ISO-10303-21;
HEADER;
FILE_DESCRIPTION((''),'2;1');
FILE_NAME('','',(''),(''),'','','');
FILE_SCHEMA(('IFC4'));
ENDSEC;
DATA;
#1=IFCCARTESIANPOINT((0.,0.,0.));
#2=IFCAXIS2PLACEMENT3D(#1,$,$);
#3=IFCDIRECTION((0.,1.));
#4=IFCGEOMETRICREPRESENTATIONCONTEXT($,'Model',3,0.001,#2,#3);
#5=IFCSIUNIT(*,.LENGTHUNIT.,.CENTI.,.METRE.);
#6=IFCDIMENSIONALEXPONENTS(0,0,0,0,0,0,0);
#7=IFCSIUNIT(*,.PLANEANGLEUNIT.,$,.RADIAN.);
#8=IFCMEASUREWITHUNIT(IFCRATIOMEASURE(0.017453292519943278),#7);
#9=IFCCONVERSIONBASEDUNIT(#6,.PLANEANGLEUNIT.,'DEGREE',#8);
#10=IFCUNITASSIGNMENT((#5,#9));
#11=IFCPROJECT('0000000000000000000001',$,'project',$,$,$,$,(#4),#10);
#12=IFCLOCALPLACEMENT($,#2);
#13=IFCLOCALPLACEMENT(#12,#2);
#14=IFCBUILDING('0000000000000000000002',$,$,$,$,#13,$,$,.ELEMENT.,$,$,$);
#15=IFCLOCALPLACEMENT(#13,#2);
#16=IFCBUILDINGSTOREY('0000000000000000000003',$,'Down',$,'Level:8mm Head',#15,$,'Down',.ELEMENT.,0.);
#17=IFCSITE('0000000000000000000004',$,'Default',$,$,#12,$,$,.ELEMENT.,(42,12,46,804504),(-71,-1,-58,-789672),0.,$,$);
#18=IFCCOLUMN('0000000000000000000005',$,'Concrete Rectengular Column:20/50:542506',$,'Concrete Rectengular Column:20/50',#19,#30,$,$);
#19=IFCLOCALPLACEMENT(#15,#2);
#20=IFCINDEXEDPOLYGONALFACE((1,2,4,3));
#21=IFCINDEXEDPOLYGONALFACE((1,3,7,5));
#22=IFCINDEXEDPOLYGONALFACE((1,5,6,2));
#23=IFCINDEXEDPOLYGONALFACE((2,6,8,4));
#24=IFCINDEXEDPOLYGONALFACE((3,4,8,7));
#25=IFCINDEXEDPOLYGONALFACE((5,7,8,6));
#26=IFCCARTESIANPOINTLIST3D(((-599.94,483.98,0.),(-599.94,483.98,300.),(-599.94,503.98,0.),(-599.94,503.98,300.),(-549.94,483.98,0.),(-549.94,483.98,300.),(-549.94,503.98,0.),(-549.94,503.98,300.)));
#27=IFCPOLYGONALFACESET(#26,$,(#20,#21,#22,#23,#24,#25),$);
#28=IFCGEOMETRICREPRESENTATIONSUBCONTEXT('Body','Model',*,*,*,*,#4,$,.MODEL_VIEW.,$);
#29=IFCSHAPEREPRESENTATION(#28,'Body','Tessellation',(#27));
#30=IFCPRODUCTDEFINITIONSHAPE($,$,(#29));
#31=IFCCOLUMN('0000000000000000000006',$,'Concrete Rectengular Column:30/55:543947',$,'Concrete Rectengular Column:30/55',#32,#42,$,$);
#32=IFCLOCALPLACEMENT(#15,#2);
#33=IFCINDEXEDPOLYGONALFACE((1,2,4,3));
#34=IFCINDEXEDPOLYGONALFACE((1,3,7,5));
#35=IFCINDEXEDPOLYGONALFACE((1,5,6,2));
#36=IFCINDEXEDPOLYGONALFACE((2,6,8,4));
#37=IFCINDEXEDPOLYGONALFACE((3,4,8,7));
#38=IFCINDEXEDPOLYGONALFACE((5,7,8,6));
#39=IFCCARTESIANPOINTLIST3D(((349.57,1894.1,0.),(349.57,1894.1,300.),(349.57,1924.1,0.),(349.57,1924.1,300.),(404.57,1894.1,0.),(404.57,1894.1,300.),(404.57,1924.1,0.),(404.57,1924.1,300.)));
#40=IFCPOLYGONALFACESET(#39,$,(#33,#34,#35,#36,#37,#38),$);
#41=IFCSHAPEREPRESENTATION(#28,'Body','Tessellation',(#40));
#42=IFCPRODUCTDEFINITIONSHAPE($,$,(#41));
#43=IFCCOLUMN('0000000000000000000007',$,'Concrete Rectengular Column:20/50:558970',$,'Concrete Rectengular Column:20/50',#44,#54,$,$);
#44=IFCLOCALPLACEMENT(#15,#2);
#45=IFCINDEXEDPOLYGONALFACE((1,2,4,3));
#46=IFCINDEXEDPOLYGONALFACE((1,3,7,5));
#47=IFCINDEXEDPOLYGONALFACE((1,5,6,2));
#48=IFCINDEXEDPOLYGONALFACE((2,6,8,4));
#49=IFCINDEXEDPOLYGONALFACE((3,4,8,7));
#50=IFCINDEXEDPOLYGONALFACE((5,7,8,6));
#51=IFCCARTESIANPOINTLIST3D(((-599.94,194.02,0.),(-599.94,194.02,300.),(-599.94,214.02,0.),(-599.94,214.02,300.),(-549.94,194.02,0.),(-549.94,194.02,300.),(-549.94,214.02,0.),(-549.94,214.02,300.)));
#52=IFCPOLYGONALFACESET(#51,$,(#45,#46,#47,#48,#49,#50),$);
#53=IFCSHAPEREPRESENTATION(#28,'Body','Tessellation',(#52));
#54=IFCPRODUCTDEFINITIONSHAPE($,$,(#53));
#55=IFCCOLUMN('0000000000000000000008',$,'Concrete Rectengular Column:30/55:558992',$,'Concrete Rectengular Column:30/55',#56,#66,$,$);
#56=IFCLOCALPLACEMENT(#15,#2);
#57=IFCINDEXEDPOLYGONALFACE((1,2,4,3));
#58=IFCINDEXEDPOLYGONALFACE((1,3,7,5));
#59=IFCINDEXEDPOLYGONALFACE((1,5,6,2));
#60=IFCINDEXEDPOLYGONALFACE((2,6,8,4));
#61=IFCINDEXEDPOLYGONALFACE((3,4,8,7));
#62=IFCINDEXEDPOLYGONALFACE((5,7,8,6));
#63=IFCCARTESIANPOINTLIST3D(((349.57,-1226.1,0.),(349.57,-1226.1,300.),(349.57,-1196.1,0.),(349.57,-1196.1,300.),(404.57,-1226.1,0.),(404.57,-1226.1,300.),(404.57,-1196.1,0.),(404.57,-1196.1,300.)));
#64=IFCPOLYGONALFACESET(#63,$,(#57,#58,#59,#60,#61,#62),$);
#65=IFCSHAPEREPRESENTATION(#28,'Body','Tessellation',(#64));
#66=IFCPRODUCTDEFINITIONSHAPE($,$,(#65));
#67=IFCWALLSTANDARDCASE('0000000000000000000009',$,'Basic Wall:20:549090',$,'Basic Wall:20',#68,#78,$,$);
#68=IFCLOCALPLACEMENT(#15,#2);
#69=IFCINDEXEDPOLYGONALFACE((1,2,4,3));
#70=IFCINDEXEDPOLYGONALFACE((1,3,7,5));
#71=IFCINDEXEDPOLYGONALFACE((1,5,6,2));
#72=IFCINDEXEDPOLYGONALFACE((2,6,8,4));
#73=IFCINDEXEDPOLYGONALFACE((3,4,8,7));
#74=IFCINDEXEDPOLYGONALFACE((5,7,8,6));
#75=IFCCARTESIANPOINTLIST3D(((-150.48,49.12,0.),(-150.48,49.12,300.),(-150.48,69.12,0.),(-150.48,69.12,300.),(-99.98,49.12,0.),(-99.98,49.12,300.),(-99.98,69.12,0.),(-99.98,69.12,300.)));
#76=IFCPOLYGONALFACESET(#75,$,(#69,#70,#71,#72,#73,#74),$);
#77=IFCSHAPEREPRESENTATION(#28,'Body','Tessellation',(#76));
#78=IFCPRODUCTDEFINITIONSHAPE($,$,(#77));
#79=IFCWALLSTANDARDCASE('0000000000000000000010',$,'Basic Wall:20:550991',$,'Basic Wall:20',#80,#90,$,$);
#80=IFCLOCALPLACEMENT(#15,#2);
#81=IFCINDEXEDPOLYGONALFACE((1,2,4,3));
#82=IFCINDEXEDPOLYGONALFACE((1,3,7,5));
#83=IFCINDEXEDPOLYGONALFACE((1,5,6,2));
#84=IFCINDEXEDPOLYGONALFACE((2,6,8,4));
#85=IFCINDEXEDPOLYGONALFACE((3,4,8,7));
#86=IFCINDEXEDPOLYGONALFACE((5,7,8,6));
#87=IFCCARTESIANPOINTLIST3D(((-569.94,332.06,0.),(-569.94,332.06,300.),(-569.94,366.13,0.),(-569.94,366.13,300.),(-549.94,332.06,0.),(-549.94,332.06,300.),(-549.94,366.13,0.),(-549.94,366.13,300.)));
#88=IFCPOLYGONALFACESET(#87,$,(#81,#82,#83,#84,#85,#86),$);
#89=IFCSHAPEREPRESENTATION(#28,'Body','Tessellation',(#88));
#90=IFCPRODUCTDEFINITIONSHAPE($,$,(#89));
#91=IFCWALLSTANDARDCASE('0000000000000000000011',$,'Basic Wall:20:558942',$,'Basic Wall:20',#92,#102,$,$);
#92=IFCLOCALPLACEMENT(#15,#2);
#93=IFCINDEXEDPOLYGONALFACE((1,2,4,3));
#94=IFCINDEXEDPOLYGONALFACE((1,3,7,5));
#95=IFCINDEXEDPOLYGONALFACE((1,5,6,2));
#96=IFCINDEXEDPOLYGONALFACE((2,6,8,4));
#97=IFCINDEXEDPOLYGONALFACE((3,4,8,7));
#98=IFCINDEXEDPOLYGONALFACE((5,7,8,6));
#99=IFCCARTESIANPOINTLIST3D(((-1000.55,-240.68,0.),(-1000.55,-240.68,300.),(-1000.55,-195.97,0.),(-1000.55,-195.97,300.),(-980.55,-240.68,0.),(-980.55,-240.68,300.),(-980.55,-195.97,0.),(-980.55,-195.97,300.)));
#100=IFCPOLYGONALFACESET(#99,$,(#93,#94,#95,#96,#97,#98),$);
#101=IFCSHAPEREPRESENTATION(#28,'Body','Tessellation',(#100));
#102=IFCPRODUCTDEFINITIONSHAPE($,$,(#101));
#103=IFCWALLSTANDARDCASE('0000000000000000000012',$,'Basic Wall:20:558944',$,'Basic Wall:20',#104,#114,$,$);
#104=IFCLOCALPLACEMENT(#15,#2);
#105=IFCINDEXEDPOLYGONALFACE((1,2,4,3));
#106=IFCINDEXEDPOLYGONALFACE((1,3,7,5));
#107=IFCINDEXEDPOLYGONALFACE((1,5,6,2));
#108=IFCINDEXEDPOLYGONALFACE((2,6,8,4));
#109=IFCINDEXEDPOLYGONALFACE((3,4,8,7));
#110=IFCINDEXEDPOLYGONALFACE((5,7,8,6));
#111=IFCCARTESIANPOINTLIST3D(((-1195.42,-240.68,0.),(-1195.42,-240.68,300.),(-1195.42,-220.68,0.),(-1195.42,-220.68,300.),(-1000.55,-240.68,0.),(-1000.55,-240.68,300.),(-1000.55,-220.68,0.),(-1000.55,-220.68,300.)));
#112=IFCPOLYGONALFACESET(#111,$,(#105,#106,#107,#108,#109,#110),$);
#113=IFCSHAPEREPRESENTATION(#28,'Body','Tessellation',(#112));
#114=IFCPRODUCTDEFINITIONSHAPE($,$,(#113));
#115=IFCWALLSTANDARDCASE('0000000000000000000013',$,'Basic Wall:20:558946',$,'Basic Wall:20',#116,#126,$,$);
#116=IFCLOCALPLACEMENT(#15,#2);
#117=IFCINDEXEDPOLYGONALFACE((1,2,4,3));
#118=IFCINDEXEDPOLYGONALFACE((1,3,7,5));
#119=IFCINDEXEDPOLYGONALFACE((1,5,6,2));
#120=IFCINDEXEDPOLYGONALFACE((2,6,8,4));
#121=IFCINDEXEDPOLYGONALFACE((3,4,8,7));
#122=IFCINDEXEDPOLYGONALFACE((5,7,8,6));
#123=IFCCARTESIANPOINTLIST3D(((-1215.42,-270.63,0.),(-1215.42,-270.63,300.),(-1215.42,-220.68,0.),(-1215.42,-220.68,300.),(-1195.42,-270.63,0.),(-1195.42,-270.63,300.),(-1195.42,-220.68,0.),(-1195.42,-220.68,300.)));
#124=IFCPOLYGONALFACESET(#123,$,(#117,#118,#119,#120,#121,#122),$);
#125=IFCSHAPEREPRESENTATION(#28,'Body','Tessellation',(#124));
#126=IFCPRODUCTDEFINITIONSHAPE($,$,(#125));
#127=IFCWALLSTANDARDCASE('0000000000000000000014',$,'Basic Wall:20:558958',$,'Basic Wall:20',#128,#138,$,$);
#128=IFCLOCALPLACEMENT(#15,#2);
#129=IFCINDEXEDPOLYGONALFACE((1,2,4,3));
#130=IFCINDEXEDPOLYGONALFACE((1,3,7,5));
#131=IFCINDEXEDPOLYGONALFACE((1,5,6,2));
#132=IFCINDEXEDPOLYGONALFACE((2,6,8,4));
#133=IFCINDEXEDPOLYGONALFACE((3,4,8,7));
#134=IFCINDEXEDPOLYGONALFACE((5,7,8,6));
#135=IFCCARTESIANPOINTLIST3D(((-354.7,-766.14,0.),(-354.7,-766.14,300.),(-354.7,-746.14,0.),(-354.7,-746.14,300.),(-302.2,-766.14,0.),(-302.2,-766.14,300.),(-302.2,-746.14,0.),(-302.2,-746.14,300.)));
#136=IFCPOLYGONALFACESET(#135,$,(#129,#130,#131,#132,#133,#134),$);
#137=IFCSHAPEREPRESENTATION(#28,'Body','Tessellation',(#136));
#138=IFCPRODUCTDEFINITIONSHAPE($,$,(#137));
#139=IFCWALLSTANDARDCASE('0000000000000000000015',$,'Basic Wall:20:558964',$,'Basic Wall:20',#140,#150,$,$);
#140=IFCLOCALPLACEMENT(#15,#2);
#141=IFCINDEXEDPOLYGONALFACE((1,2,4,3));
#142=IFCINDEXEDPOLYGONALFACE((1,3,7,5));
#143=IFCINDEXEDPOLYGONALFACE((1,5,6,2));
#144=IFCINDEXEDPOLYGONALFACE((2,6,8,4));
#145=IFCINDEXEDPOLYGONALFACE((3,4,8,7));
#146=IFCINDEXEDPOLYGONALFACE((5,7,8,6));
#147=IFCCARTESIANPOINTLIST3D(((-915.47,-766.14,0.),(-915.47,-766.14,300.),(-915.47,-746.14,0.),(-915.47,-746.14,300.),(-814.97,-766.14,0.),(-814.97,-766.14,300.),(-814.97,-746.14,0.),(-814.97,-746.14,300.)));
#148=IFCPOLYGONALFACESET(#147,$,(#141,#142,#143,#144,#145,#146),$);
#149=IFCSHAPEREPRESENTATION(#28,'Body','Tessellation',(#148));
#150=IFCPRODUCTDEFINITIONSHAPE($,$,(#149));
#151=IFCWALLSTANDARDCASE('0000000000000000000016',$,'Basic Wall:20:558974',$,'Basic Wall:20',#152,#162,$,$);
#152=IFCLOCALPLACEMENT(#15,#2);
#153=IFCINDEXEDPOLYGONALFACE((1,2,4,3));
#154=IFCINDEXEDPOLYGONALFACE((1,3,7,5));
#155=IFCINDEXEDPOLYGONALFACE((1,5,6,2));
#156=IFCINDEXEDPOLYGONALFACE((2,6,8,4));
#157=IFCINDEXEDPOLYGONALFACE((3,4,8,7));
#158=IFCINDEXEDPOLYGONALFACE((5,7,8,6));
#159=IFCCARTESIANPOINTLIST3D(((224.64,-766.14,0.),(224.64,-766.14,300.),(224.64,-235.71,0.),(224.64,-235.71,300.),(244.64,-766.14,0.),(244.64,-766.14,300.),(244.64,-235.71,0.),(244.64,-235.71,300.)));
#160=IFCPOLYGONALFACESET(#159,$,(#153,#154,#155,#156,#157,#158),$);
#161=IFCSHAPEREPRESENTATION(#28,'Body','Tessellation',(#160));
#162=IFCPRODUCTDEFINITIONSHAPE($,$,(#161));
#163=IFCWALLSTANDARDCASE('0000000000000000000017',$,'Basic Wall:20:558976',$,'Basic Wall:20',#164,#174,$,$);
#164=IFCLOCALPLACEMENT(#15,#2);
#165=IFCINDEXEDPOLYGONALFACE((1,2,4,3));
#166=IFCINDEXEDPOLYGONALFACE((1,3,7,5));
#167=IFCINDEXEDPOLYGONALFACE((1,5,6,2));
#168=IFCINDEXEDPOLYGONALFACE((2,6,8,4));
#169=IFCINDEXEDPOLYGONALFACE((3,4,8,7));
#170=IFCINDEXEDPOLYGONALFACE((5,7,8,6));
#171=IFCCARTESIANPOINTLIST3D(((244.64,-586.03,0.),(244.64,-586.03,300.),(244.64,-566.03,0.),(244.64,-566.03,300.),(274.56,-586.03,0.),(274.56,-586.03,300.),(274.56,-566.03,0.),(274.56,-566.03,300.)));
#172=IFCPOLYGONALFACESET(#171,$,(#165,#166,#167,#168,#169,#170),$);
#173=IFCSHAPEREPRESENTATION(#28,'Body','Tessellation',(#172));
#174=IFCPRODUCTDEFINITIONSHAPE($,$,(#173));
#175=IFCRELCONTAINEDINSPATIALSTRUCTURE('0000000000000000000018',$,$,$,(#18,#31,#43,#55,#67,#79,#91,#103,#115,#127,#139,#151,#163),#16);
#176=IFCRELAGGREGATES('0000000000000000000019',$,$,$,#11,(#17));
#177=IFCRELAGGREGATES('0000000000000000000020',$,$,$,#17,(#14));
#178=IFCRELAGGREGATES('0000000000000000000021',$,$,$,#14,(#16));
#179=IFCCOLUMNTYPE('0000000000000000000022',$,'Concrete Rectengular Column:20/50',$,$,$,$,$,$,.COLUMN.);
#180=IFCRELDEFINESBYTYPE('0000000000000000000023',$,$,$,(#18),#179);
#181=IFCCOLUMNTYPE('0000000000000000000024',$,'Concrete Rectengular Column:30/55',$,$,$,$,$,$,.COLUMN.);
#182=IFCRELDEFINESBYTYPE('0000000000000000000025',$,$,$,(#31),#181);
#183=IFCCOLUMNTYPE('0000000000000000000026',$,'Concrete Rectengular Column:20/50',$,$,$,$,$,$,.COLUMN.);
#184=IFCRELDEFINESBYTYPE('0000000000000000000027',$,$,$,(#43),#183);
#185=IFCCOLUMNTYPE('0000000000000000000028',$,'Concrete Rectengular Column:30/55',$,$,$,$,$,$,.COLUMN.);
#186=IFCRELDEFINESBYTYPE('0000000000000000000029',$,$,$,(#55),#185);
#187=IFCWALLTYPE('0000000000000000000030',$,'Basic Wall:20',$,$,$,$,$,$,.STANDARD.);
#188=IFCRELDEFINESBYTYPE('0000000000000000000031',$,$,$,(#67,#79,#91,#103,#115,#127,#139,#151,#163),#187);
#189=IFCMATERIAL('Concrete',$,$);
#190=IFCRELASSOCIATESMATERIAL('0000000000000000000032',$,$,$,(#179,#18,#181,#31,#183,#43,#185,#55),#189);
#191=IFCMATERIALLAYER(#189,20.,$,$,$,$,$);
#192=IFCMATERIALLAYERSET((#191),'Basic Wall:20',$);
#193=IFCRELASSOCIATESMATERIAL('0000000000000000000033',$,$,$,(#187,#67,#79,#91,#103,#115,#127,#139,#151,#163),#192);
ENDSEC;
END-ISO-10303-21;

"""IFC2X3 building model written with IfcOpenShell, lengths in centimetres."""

from ifc_helpers import new_model, entity, si_unit, converted_unit, direction, frame, frame_2d, origin, origin_2d_with_axis, place, context, subcontext, project, spatial, rectangle, extrude, source, transform, mapped, material, layer, layer_set, layer_usage, type_object, type_shapes, element, save


model = new_model("IFC2X3")

# Units and contexts
model_context = context("Model", 3, precision=0.001, world=origin(), true_north=direction((0.0, 1.0)))
body_context = subcontext(model_context, "Body", "Model", "MODEL_VIEW")
ifc_project = project(units=[si_unit("LENGTHUNIT", "METRE", prefix="CENTI"), converted_unit("PLANEANGLEUNIT", "DEGREE", entity("IfcRatioMeasure", 0.017453292519943278), si_unit("PLANEANGLEUNIT", "RADIAN"), dimensions=[0, 0, 0, 0, 0, 0, 0])], contexts=[model_context])

# Site, building, storey
site_placement = place(None, origin())
site = spatial("IfcSite", under=ifc_project, at=site_placement, Name="Default", CompositionType="ELEMENT", RefLatitude=(42, 12, 46, 804504), RefLongitude=(-71, -1, -58, -789672), RefElevation=0.0)
building_placement = place(site_placement, origin())
building = spatial("IfcBuilding", under=site, at=building_placement, CompositionType="ELEMENT")
storey_placement = place(building_placement, origin())
storey = spatial("IfcBuildingStorey", under=building, at=storey_placement, Name="Down", ObjectType="Level:8mm Head", LongName="Down", CompositionType="ELEMENT", Elevation=0.0)

# Columns
ifc_material = material(Name="Concrete")
column_type_1 = type_object("IfcColumnType", Name="Concrete Rectengular Column:20/50", PredefinedType="COLUMN", material=ifc_material)
shared_shape_1 = source(origin(), body_context, "Body", "SweptSolid", [
    extrude(rectangle(XDim=20.0, YDim=50.0, at=frame_2d((0.0, 0.0), x_axis=(1.0, 0.0))), frame((-574.94, 493.98, 0.0), z_axis=(0.0, 0.0, 1.0), x_axis=(0.0, -1.0, 0.0)), (0.0, 0.0, 1.0), 300.0),
])
type_shapes(column_type_1, [shared_shape_1])
column_1_placement = place(storey_placement, origin())
element("IfcColumn", 1, at=column_1_placement, inside=storey, type_object=column_type_1, material=ifc_material, Name="Concrete Rectengular Column:20/50:542506", ObjectType="Concrete Rectengular Column:20/50", context=body_context, shape_type="MappedRepresentation", body=[
    mapped(shared_shape_1, transform((0.0, 0.0, 0.0), scale=1.0)),
])
column_type_2 = type_object("IfcColumnType", Name="Concrete Rectengular Column:30/55", PredefinedType="COLUMN", material=ifc_material)
shared_shape_2 = source(origin(), body_context, "Body", "SweptSolid", [
    extrude(rectangle(XDim=30.0, YDim=55.0, at=origin_2d_with_axis()), frame((377.07, 1909.1, 0.0), z_axis=(0.0, 0.0, 1.0), x_axis=(0.0, -1.0, 0.0)), (0.0, 0.0, 1.0), 300.0),
])
type_shapes(column_type_2, [shared_shape_2])
column_2_placement = place(storey_placement, origin())
element("IfcColumn", 2, at=column_2_placement, inside=storey, type_object=column_type_2, material=ifc_material, Name="Concrete Rectengular Column:30/55:543947", ObjectType="Concrete Rectengular Column:30/55", context=body_context, shape_type="MappedRepresentation", body=[
    mapped(shared_shape_2, transform((0.0, 0.0, 0.0), scale=1.0)),
])
column_type_3 = type_object("IfcColumnType", Name="Concrete Rectengular Column:20/50", PredefinedType="COLUMN", material=ifc_material)
shared_shape_3 = source(origin(), body_context, "Body", "SweptSolid", [
    extrude(rectangle(XDim=20.0, YDim=50.0, at=frame_2d((0.0, 0.0), x_axis=(1.0, 0.0))), frame((-574.94, 204.02, 0.0), z_axis=(0.0, 0.0, 1.0), x_axis=(0.0, -1.0, 0.0)), (0.0, 0.0, 1.0), 300.0),
])
type_shapes(column_type_3, [shared_shape_3])
column_3_placement = place(storey_placement, origin())
element("IfcColumn", 3, at=column_3_placement, inside=storey, type_object=column_type_3, material=ifc_material, Name="Concrete Rectengular Column:20/50:558970", ObjectType="Concrete Rectengular Column:20/50", context=body_context, shape_type="MappedRepresentation", body=[
    mapped(shared_shape_3, transform((0.0, 0.0, 0.0), scale=1.0)),
])
column_type_4 = type_object("IfcColumnType", Name="Concrete Rectengular Column:30/55", PredefinedType="COLUMN", material=ifc_material)
shared_shape_4 = source(origin(), body_context, "Body", "SweptSolid", [
    extrude(rectangle(XDim=30.0, YDim=55.0, at=origin_2d_with_axis()), frame((377.07, -1211.1, 0.0), z_axis=(0.0, 0.0, 1.0), x_axis=(0.0, -1.0, 0.0)), (0.0, 0.0, 1.0), 300.0),
])
type_shapes(column_type_4, [shared_shape_4])
column_4_placement = place(storey_placement, origin())
element("IfcColumn", 4, at=column_4_placement, inside=storey, type_object=column_type_4, material=ifc_material, Name="Concrete Rectengular Column:30/55:558992", ObjectType="Concrete Rectengular Column:30/55", context=body_context, shape_type="MappedRepresentation", body=[
    mapped(shared_shape_4, transform((0.0, 0.0, 0.0), scale=1.0)),
])

# Walls
ifc_layer_1 = layer(ifc_material, 20.0)
ifc_layer_set_1 = layer_set([ifc_layer_1], Name="Basic Wall:20")
ifc_layer_usage_1 = layer_usage(ifc_layer_set_1, "AXIS2", "POSITIVE", -10.0)
wall_type_1 = type_object("IfcWallType", Name="Basic Wall:20", PredefinedType="STANDARD", material=ifc_layer_set_1)
wall_1_placement = place(storey_placement, frame((-150.48, 59.12, 0.0)))
element("IfcWallStandardCase", 5, at=wall_1_placement, inside=storey, type_object=wall_type_1, material=ifc_layer_usage_1, Name="Basic Wall:20:549090", ObjectType="Basic Wall:20", context=body_context, shape_type="SweptSolid", body=[
    extrude(rectangle(XDim=50.5, YDim=20.0, at=frame_2d((25.25, 0.0), x_axis=(-1.0, 0.0))), origin(), (0.0, 0.0, 1.0), 300.0),
])
ifc_layer_usage_2 = layer_usage(ifc_layer_set_1, "AXIS2", "NEGATIVE", 10.0)
wall_2_placement = place(storey_placement, frame((-559.94, 332.06, 0.0), z_axis=(0.0, 0.0, 1.0), x_axis=(0.0, 1.0, 0.0)))
element("IfcWallStandardCase", 6, at=wall_2_placement, inside=storey, type_object=wall_type_1, material=ifc_layer_usage_2, Name="Basic Wall:20:550991", ObjectType="Basic Wall:20", context=body_context, shape_type="SweptSolid", body=[
    extrude(rectangle(XDim=34.08, YDim=20.0, at=frame_2d((17.04, 0.0), x_axis=(-1.0, 0.0))), origin(), (0.0, 0.0, 1.0), 300.0),
])
ifc_layer_usage_3 = layer_usage(ifc_layer_set_1, "AXIS2", "NEGATIVE", 10.0)
wall_3_placement = place(storey_placement, frame((-990.55, -195.97, 0.0), z_axis=(0.0, 0.0, 1.0), x_axis=(0.0, -1.0, 0.0)))
element("IfcWallStandardCase", 7, at=wall_3_placement, inside=storey, type_object=wall_type_1, material=ifc_layer_usage_3, Name="Basic Wall:20:558942", ObjectType="Basic Wall:20", context=body_context, shape_type="SweptSolid", body=[
    extrude(rectangle(XDim=44.71, YDim=20.0, at=frame_2d((22.36, 0.0), x_axis=(-1.0, 0.0))), origin(), (0.0, 0.0, 1.0), 300.0),
])
ifc_layer_usage_4 = layer_usage(ifc_layer_set_1, "AXIS2", "NEGATIVE", 10.0)
wall_4_placement = place(storey_placement, frame((-1000.55, -230.68, 0.0), z_axis=(0.0, 0.0, 1.0), x_axis=(-1.0, 0.0, 0.0)))
element("IfcWallStandardCase", 8, at=wall_4_placement, inside=storey, type_object=wall_type_1, material=ifc_layer_usage_4, Name="Basic Wall:20:558944", ObjectType="Basic Wall:20", context=body_context, shape_type="SweptSolid", body=[
    extrude(rectangle(XDim=194.87, YDim=20.0, at=frame_2d((97.44, 0.0), x_axis=(-1.0, 0.0))), origin(), (0.0, 0.0, 1.0), 300.0),
])
ifc_layer_usage_5 = layer_usage(ifc_layer_set_1, "AXIS2", "POSITIVE", -10.0)
wall_5_placement = place(storey_placement, frame((-1205.42, -220.68, 0.0), z_axis=(0.0, 0.0, 1.0), x_axis=(0.0, -1.0, 0.0)))
element("IfcWallStandardCase", 9, at=wall_5_placement, inside=storey, type_object=wall_type_1, material=ifc_layer_usage_5, Name="Basic Wall:20:558946", ObjectType="Basic Wall:20", context=body_context, shape_type="SweptSolid", body=[
    extrude(rectangle(XDim=49.95, YDim=20.0, at=frame_2d((24.98, 0.0), x_axis=(-1.0, 0.0))), origin(), (0.0, 0.0, 1.0), 300.0),
])
ifc_layer_usage_6 = layer_usage(ifc_layer_set_1, "AXIS2", "NEGATIVE", 10.0)
wall_6_placement = place(storey_placement, frame((-302.2, -756.14, 0.0), z_axis=(0.0, 0.0, 1.0), x_axis=(-1.0, 0.0, 0.0)))
element("IfcWallStandardCase", 10, at=wall_6_placement, inside=storey, type_object=wall_type_1, material=ifc_layer_usage_6, Name="Basic Wall:20:558958", ObjectType="Basic Wall:20", context=body_context, shape_type="SweptSolid", body=[
    extrude(rectangle(XDim=52.5, YDim=20.0, at=frame_2d((26.25, 0.0), x_axis=(-1.0, 0.0))), origin(), (0.0, 0.0, 1.0), 300.0),
])
ifc_layer_usage_7 = layer_usage(ifc_layer_set_1, "AXIS2", "POSITIVE", -10.0)
wall_7_placement = place(storey_placement, frame((-915.47, -756.14, 0.0)))
element("IfcWallStandardCase", 11, at=wall_7_placement, inside=storey, type_object=wall_type_1, material=ifc_layer_usage_7, Name="Basic Wall:20:558964", ObjectType="Basic Wall:20", context=body_context, shape_type="SweptSolid", body=[
    extrude(rectangle(XDim=100.5, YDim=20.0, at=frame_2d((50.25, 0.0), x_axis=(-1.0, 0.0))), origin(), (0.0, 0.0, 1.0), 300.0),
])
ifc_layer_usage_8 = layer_usage(ifc_layer_set_1, "AXIS2", "NEGATIVE", 10.0)
wall_8_placement = place(storey_placement, frame((234.64, -766.14, 0.0), z_axis=(0.0, 0.0, 1.0), x_axis=(0.0, 1.0, 0.0)))
element("IfcWallStandardCase", 12, at=wall_8_placement, inside=storey, type_object=wall_type_1, material=ifc_layer_usage_8, Name="Basic Wall:20:558974", ObjectType="Basic Wall:20", context=body_context, shape_type="SweptSolid", body=[
    extrude(rectangle(XDim=530.43, YDim=20.0, at=frame_2d((265.22, 0.0), x_axis=(-1.0, 0.0))), origin(), (0.0, 0.0, 1.0), 300.0),
])
ifc_layer_usage_9 = layer_usage(ifc_layer_set_1, "AXIS2", "POSITIVE", -10.0)
wall_9_placement = place(storey_placement, frame((274.56, -576.03, 0.0), z_axis=(0.0, 0.0, 1.0), x_axis=(-1.0, 0.0, 0.0)))
element("IfcWallStandardCase", 13, at=wall_9_placement, inside=storey, type_object=wall_type_1, material=ifc_layer_usage_9, Name="Basic Wall:20:558976", ObjectType="Basic Wall:20", context=body_context, shape_type="SweptSolid", body=[
    extrude(rectangle(XDim=29.92, YDim=20.0, at=frame_2d((14.96, 0.0), x_axis=(-1.0, 0.0))), origin(), (0.0, 0.0, 1.0), 300.0),
])

save(model, "model.ifc")
